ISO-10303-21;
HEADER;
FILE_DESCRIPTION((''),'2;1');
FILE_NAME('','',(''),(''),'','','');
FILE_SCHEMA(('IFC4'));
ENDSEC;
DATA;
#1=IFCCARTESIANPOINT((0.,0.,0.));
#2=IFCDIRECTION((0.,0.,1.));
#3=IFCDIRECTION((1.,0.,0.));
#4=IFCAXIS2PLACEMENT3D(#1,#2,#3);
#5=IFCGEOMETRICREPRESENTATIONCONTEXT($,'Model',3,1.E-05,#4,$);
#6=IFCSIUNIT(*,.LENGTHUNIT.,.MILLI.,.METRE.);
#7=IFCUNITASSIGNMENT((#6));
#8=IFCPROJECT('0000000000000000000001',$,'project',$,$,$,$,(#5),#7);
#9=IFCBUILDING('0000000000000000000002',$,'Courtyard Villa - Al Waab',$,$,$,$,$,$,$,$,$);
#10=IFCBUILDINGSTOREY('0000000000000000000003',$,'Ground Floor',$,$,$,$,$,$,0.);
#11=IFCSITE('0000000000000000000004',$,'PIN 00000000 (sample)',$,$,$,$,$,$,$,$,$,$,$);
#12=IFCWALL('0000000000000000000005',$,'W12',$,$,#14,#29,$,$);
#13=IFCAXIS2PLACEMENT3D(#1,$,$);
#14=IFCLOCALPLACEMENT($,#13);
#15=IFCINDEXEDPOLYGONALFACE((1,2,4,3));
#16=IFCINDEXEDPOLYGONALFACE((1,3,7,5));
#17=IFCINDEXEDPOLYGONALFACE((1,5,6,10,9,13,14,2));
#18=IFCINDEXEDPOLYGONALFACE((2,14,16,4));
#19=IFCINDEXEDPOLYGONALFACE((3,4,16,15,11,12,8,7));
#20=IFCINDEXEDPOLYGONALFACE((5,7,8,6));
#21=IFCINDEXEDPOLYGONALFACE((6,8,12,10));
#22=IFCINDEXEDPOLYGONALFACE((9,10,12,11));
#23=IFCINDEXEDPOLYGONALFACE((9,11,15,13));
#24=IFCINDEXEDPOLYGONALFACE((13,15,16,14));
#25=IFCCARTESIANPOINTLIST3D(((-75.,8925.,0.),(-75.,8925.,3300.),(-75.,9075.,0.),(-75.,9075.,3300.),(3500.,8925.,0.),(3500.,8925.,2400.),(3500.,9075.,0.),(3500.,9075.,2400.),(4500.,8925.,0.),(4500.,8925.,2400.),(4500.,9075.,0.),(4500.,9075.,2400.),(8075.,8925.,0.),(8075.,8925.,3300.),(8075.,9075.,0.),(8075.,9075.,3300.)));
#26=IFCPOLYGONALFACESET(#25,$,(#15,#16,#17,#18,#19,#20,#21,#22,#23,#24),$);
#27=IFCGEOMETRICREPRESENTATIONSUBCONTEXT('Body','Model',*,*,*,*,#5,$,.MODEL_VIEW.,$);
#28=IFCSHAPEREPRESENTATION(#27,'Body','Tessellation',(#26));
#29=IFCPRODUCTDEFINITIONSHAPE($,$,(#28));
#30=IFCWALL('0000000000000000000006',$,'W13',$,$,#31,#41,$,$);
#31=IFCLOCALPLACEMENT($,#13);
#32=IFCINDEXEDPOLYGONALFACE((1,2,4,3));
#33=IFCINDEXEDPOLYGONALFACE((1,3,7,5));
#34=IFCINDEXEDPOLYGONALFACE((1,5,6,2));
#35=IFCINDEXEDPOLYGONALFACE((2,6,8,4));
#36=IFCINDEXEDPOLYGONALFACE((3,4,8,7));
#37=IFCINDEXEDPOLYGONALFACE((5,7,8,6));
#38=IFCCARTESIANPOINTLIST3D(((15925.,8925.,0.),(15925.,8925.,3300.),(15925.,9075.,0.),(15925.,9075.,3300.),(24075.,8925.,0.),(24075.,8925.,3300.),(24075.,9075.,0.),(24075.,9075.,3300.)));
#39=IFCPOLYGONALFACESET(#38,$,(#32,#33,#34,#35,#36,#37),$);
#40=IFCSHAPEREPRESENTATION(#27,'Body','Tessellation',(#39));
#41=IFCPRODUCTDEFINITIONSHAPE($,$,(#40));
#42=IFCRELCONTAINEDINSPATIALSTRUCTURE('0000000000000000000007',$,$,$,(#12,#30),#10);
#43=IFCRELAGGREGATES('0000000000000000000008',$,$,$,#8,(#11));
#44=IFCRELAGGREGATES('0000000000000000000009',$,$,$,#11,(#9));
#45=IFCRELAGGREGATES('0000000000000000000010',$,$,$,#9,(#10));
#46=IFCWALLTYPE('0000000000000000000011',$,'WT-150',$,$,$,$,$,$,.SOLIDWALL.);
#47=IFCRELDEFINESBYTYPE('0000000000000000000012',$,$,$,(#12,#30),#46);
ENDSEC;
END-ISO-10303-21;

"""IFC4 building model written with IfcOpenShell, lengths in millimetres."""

from ifc_helpers import new_model, si_unit, frame, origin_with_axes, place, context, subcontext, project, spatial, indexed_curve, outline, extrude, type_object, element, save


model = new_model("IFC4")

# Units and contexts
model_context = context("Model", 3, precision=1e-05, world=origin_with_axes())
body_context = subcontext(model_context, "Body", "Model", "MODEL_VIEW")
ifc_project = project(units=[si_unit("LENGTHUNIT", "METRE", prefix="MILLI")], contexts=[model_context])

# Site, building, storey
site = spatial("IfcSite", under=ifc_project, Name="PIN 00000000 (sample)")
building = spatial("IfcBuilding", under=site, Name="Courtyard Villa - Al Waab")
storey = spatial("IfcBuildingStorey", under=building, Name="Ground Floor", Elevation=0.0)

# Shared definitions
wall_type_1 = type_object("IfcWallType", Name="WT-150", PredefinedType="SOLIDWALL")

# Wall, opening
wall_1_placement = place(None, frame((-75.0, 8925.0, 0.0), z_axis=(0.0, 0.0, 1.0), x_axis=(1.0, 0.0, 0.0)))
wall_1 = element("IfcWall", 1, at=wall_1_placement, inside=storey, type_object=wall_type_1, Name="W12", context=body_context, shape_type="SweptSolid", body=[
    extrude(outline(indexed_curve([(0.0, 0.0), (0.0, 150.0), (8150.0, 150.0), (8150.0, 0.0), (0.0, 0.0)], self_intersect=False)), origin_with_axes(), (0.0, 0.0, 1.0), 3300.0),
])
opening_1_placement = place(wall_1_placement, frame((3575.0, -100.0, 0.0), z_axis=(0.0, 0.0, 1.0), x_axis=(1.0, 0.0, 0.0)))
element("IfcOpeningElement", 2, at=opening_1_placement, cuts=wall_1, context=body_context, shape_type="SweptSolid", body=[
    extrude(outline(indexed_curve([(0.0, 0.0), (0.0, 350.0), (1000.0, 350.0), (1000.0, 0.0), (0.0, 0.0)], self_intersect=False)), origin_with_axes(), (0.0, 0.0, 1.0), 2400.0),
])

# Wall
wall_2_placement = place(None, frame((15925.0, 8925.0, 0.0), z_axis=(0.0, 0.0, 1.0), x_axis=(1.0, 0.0, 0.0)))
element("IfcWall", 3, at=wall_2_placement, inside=storey, type_object=wall_type_1, Name="W13", context=body_context, shape_type="SweptSolid", body=[
    extrude(outline(indexed_curve([(0.0, 0.0), (0.0, 150.0), (8150.0, 150.0), (8150.0, 0.0), (0.0, 0.0)], self_intersect=False)), origin_with_axes(), (0.0, 0.0, 1.0), 3300.0),
])

save(model, "model.ifc")
